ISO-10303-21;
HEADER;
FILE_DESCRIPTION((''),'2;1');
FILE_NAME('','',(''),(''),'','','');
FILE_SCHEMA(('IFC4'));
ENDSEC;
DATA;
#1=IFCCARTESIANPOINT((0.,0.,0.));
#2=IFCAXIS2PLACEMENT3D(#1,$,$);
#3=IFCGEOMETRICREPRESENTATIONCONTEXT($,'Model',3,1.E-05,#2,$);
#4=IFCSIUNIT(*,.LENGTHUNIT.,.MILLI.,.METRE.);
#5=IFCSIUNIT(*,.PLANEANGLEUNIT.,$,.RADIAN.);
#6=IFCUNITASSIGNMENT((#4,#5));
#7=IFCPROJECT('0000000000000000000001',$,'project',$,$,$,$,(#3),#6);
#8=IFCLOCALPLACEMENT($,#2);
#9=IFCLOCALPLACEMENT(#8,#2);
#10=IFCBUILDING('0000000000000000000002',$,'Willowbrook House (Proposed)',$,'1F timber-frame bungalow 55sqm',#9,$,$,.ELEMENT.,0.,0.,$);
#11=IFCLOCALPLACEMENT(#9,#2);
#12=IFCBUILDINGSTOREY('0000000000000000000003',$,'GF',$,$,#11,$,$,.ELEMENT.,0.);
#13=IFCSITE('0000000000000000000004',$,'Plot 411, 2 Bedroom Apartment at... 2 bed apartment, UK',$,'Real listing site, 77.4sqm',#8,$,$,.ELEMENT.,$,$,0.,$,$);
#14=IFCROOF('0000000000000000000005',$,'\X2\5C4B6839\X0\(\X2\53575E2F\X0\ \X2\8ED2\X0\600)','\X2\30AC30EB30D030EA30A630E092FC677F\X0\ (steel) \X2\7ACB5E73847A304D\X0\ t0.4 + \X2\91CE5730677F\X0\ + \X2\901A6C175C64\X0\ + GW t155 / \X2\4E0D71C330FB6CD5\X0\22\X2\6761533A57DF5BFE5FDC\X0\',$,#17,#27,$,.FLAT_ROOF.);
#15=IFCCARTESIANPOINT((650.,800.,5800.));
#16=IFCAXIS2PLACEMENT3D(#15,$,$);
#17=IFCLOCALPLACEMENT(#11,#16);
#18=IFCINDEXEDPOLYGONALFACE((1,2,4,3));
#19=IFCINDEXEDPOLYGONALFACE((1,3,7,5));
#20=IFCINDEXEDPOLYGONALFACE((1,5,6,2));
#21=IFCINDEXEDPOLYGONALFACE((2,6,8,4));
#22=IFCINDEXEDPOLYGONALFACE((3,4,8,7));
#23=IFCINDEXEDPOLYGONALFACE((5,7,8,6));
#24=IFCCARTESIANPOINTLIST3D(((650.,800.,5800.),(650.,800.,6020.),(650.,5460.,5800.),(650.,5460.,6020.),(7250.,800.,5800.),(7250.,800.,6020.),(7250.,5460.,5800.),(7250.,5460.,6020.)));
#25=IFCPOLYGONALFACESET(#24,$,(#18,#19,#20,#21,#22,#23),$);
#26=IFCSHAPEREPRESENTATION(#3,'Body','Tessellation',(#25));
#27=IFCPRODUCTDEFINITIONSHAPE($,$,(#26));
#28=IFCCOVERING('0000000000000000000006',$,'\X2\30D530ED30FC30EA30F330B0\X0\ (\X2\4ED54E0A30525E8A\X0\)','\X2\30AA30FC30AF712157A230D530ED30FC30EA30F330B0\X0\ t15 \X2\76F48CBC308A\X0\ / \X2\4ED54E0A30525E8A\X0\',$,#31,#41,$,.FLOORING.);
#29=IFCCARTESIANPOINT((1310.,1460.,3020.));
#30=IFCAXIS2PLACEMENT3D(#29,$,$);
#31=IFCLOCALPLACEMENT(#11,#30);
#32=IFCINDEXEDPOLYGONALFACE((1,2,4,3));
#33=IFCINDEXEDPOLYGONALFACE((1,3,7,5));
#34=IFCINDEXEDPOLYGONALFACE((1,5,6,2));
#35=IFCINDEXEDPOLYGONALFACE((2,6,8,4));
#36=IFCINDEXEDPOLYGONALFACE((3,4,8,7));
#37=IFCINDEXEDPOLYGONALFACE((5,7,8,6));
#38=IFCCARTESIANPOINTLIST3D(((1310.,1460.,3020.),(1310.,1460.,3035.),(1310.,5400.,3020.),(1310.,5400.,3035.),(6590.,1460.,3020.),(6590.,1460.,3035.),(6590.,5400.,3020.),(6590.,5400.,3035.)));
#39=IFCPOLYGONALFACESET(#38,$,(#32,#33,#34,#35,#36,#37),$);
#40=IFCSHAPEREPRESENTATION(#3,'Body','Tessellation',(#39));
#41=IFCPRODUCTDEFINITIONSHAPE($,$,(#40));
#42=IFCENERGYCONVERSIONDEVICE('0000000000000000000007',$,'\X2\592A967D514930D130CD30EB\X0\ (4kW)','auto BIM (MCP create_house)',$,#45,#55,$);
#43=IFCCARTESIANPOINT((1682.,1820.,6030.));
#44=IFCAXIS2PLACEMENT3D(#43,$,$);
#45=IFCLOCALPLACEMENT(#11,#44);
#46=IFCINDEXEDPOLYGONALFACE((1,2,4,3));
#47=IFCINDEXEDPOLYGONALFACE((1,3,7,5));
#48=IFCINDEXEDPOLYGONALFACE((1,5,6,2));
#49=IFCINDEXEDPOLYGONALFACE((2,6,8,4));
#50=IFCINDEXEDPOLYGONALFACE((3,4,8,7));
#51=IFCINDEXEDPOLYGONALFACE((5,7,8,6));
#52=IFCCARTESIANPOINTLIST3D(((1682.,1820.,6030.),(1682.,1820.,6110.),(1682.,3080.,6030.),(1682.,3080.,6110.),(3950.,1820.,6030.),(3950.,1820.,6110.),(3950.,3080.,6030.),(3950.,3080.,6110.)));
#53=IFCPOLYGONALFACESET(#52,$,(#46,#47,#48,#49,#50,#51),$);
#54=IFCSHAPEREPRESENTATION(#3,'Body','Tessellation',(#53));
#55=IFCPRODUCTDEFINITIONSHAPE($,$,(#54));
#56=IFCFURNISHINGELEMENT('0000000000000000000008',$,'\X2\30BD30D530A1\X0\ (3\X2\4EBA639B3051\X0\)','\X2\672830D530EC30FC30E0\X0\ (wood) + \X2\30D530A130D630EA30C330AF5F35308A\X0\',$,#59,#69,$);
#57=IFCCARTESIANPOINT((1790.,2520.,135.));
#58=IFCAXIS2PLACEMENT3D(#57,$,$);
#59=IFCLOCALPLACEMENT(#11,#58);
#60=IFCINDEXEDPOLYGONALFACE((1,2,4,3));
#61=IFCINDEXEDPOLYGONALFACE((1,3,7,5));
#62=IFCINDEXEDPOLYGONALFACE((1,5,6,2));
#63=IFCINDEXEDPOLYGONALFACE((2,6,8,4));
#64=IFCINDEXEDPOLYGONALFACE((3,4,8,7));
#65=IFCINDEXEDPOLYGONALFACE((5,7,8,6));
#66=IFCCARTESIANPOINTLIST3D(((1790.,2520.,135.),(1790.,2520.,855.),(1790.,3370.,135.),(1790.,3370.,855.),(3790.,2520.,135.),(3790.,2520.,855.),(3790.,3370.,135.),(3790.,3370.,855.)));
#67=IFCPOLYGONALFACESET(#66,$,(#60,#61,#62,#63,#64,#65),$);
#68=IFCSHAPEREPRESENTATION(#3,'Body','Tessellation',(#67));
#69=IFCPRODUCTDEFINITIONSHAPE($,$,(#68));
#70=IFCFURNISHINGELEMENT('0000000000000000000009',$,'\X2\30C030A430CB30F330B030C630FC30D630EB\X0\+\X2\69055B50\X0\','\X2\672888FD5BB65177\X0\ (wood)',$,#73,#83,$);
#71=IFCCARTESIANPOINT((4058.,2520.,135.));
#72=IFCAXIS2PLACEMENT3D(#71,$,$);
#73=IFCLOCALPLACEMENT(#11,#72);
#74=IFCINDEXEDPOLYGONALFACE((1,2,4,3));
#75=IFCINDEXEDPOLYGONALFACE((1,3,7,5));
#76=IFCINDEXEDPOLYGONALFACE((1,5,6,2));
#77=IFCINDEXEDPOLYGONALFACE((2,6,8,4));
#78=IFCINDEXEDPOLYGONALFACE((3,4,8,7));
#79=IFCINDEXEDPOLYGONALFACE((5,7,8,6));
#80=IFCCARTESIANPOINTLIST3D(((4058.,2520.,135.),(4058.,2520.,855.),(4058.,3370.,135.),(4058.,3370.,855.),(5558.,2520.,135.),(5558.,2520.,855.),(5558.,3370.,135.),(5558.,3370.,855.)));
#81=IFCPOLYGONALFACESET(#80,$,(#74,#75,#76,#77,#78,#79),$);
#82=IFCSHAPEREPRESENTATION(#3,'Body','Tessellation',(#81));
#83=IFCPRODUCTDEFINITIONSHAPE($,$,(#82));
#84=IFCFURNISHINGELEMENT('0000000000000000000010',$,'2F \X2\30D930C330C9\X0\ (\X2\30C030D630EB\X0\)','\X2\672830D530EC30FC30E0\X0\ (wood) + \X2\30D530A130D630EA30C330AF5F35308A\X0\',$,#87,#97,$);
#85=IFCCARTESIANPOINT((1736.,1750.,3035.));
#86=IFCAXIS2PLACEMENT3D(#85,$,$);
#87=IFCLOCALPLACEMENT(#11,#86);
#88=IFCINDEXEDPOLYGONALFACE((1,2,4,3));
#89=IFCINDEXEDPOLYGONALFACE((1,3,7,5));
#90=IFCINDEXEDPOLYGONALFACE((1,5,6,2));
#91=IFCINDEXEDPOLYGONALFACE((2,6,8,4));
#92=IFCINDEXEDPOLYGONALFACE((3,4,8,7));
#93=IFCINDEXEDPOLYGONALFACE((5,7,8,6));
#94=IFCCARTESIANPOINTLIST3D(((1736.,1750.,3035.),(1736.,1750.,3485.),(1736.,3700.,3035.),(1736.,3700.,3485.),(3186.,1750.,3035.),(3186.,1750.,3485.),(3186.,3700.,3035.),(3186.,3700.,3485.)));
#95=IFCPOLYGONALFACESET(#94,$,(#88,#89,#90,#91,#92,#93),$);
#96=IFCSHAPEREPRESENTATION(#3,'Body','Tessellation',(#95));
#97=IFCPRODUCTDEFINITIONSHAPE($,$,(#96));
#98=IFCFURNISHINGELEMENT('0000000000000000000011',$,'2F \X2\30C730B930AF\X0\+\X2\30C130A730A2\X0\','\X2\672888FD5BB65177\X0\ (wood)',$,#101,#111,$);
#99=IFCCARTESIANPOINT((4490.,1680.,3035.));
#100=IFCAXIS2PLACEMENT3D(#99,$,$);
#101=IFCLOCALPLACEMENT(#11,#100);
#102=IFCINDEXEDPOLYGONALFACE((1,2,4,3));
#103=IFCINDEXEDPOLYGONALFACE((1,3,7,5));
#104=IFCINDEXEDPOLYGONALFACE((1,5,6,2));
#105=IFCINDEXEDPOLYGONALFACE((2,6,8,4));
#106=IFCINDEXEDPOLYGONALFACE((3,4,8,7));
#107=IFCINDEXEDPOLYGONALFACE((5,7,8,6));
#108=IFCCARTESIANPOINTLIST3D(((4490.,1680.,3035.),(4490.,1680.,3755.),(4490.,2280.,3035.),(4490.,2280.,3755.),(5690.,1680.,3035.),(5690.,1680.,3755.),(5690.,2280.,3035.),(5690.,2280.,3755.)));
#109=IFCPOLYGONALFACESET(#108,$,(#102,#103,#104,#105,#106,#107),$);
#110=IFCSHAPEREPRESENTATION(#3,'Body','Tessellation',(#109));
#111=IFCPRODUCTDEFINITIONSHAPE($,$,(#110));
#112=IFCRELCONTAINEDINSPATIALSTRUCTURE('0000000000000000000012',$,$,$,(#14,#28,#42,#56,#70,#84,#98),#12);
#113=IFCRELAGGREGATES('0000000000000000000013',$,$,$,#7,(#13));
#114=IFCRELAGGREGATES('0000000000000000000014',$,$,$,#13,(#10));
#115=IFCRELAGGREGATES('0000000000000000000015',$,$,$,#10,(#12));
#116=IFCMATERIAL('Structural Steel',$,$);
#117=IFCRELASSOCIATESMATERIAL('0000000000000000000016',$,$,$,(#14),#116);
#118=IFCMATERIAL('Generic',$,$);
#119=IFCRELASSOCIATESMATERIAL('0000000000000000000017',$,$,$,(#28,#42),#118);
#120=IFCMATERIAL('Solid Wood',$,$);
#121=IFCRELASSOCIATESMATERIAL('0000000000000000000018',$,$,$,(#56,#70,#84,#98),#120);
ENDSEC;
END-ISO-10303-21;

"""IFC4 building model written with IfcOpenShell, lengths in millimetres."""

from ifc_helpers import new_model, si_unit, frame, frame_2d, origin, place, context, project, spatial, rectangle, extrude, material, element, save


model = new_model("IFC4")

# Units and contexts
model_context = context("Model", 3, precision=1e-05, world=origin())
ifc_project = project(units=[si_unit("LENGTHUNIT", "METRE", prefix="MILLI"), si_unit("PLANEANGLEUNIT", "RADIAN")], contexts=[model_context])

# Site, building, storey
site_placement = place(None, origin())
site = spatial("IfcSite", under=ifc_project, at=site_placement, Name="Plot 411, 2 Bedroom Apartment at... 2 bed apartment, UK", ObjectType="Real listing site, 77.4sqm", CompositionType="ELEMENT", RefElevation=0.0)
building_placement = place(site_placement, origin())
building = spatial("IfcBuilding", under=site, at=building_placement, Name="Willowbrook House (Proposed)", ObjectType="1F timber-frame bungalow 55sqm", CompositionType="ELEMENT", ElevationOfRefHeight=0.0, ElevationOfTerrain=0.0)
storey_placement = place(building_placement, origin())
storey = spatial("IfcBuildingStorey", under=building, at=storey_placement, Name="GF", CompositionType="ELEMENT", Elevation=0.0)

# Shared definitions
ifc_material_1 = material(Name="Solid Wood")

# Shared definitions
ifc_material_2 = material(Name="Generic")

# Roof
ifc_material_3 = material(Name="Structural Steel")
for number, where, name in (
    (1, (650.0, 800.0, 5800.0), "屋根(南帯 軒600)"),
):
    element("IfcRoof", number, at=place(storey_placement, frame(where)), inside=storey, material=ifc_material_3, Name=name, Description="ガルバリウム鋼板 (steel) 立平葺き t0.4 + 野地板 + 通気層 + GW t155 / 不燃・法22条区域対応", PredefinedType="FLAT_ROOF", context=model_context, shape_type="SweptSolid", body=[
        extrude(rectangle(XDim=6600.0, YDim=4660.0, at=frame_2d((3300.0, 2330.0))), frame((650.0, 800.0, 5800.0)), (0.0, 0.0, 1.0), 220.0),
    ])

# Covering
covering_placement = place(storey_placement, frame((1310.0, 1460.0, 3020.0)))
element("IfcCovering", 2, at=covering_placement, inside=storey, material=ifc_material_2, Name="フローリング (仕上げ床)", Description="オーク無垢フローリング t15 直貼り / 仕上げ床", PredefinedType="FLOORING", context=model_context, shape_type="SweptSolid", body=[
    extrude(rectangle(XDim=5280.0, YDim=3940.0, at=frame_2d((2640.0, 1970.0))), frame((1310.0, 1460.0, 3020.0)), (0.0, 0.0, 1.0), 15.0),
])

# Energy conversion device
energy_conversion_device_placement = place(storey_placement, frame((1682.0, 1820.0, 6030.0)))
element("IfcEnergyConversionDevice", 3, at=energy_conversion_device_placement, inside=storey, material=ifc_material_2, Name="太陽光パネル (4kW)", Description="auto BIM (MCP create_house)", context=model_context, shape_type="SweptSolid", body=[
    extrude(rectangle(XDim=2268.0, YDim=1260.0, at=frame_2d((1134.0, 630.0))), frame((1682.0, 1820.0, 6030.0)), (0.0, 0.0, 1.0), 80.0),
])

# Furnishing elements
furnishing_1_placement = place(storey_placement, frame((1790.0, 2520.0, 135.0)))
element("IfcFurnishingElement", 4, at=furnishing_1_placement, inside=storey, material=ifc_material_1, Name="ソファ (3人掛け)", Description="木フレーム (wood) + ファブリック張り", context=model_context, shape_type="SweptSolid", body=[
    extrude(rectangle(XDim=2000.0, YDim=850.0, at=frame_2d((1000.0, 425.0))), frame((1790.0, 2520.0, 135.0)), (0.0, 0.0, 1.0), 720.0),
])
furnishing_2_placement = place(storey_placement, frame((4058.0, 2520.0, 135.0)))
element("IfcFurnishingElement", 5, at=furnishing_2_placement, inside=storey, material=ifc_material_1, Name="ダイニングテーブル+椅子", Description="木製家具 (wood)", context=model_context, shape_type="SweptSolid", body=[
    extrude(rectangle(XDim=1500.0, YDim=850.0, at=frame_2d((750.0, 425.0))), frame((4058.0, 2520.0, 135.0)), (0.0, 0.0, 1.0), 720.0),
])
furnishing_3_placement = place(storey_placement, frame((1736.0, 1750.0, 3035.0)))
element("IfcFurnishingElement", 6, at=furnishing_3_placement, inside=storey, material=ifc_material_1, Name="2F ベッド (ダブル)", Description="木フレーム (wood) + ファブリック張り", context=model_context, shape_type="SweptSolid", body=[
    extrude(rectangle(XDim=1450.0, YDim=1950.0, at=frame_2d((725.0, 975.0))), frame((1736.0, 1750.0, 3035.0)), (0.0, 0.0, 1.0), 450.0),
])
furnishing_4_placement = place(storey_placement, frame((4490.0, 1680.0, 3035.0)))
element("IfcFurnishingElement", 7, at=furnishing_4_placement, inside=storey, material=ifc_material_1, Name="2F デスク+チェア", Description="木製家具 (wood)", context=model_context, shape_type="SweptSolid", body=[
    extrude(rectangle(XDim=1200.0, YDim=600.0, at=frame_2d((600.0, 300.0))), frame((4490.0, 1680.0, 3035.0)), (0.0, 0.0, 1.0), 720.0),
])

save(model, "model.ifc")
